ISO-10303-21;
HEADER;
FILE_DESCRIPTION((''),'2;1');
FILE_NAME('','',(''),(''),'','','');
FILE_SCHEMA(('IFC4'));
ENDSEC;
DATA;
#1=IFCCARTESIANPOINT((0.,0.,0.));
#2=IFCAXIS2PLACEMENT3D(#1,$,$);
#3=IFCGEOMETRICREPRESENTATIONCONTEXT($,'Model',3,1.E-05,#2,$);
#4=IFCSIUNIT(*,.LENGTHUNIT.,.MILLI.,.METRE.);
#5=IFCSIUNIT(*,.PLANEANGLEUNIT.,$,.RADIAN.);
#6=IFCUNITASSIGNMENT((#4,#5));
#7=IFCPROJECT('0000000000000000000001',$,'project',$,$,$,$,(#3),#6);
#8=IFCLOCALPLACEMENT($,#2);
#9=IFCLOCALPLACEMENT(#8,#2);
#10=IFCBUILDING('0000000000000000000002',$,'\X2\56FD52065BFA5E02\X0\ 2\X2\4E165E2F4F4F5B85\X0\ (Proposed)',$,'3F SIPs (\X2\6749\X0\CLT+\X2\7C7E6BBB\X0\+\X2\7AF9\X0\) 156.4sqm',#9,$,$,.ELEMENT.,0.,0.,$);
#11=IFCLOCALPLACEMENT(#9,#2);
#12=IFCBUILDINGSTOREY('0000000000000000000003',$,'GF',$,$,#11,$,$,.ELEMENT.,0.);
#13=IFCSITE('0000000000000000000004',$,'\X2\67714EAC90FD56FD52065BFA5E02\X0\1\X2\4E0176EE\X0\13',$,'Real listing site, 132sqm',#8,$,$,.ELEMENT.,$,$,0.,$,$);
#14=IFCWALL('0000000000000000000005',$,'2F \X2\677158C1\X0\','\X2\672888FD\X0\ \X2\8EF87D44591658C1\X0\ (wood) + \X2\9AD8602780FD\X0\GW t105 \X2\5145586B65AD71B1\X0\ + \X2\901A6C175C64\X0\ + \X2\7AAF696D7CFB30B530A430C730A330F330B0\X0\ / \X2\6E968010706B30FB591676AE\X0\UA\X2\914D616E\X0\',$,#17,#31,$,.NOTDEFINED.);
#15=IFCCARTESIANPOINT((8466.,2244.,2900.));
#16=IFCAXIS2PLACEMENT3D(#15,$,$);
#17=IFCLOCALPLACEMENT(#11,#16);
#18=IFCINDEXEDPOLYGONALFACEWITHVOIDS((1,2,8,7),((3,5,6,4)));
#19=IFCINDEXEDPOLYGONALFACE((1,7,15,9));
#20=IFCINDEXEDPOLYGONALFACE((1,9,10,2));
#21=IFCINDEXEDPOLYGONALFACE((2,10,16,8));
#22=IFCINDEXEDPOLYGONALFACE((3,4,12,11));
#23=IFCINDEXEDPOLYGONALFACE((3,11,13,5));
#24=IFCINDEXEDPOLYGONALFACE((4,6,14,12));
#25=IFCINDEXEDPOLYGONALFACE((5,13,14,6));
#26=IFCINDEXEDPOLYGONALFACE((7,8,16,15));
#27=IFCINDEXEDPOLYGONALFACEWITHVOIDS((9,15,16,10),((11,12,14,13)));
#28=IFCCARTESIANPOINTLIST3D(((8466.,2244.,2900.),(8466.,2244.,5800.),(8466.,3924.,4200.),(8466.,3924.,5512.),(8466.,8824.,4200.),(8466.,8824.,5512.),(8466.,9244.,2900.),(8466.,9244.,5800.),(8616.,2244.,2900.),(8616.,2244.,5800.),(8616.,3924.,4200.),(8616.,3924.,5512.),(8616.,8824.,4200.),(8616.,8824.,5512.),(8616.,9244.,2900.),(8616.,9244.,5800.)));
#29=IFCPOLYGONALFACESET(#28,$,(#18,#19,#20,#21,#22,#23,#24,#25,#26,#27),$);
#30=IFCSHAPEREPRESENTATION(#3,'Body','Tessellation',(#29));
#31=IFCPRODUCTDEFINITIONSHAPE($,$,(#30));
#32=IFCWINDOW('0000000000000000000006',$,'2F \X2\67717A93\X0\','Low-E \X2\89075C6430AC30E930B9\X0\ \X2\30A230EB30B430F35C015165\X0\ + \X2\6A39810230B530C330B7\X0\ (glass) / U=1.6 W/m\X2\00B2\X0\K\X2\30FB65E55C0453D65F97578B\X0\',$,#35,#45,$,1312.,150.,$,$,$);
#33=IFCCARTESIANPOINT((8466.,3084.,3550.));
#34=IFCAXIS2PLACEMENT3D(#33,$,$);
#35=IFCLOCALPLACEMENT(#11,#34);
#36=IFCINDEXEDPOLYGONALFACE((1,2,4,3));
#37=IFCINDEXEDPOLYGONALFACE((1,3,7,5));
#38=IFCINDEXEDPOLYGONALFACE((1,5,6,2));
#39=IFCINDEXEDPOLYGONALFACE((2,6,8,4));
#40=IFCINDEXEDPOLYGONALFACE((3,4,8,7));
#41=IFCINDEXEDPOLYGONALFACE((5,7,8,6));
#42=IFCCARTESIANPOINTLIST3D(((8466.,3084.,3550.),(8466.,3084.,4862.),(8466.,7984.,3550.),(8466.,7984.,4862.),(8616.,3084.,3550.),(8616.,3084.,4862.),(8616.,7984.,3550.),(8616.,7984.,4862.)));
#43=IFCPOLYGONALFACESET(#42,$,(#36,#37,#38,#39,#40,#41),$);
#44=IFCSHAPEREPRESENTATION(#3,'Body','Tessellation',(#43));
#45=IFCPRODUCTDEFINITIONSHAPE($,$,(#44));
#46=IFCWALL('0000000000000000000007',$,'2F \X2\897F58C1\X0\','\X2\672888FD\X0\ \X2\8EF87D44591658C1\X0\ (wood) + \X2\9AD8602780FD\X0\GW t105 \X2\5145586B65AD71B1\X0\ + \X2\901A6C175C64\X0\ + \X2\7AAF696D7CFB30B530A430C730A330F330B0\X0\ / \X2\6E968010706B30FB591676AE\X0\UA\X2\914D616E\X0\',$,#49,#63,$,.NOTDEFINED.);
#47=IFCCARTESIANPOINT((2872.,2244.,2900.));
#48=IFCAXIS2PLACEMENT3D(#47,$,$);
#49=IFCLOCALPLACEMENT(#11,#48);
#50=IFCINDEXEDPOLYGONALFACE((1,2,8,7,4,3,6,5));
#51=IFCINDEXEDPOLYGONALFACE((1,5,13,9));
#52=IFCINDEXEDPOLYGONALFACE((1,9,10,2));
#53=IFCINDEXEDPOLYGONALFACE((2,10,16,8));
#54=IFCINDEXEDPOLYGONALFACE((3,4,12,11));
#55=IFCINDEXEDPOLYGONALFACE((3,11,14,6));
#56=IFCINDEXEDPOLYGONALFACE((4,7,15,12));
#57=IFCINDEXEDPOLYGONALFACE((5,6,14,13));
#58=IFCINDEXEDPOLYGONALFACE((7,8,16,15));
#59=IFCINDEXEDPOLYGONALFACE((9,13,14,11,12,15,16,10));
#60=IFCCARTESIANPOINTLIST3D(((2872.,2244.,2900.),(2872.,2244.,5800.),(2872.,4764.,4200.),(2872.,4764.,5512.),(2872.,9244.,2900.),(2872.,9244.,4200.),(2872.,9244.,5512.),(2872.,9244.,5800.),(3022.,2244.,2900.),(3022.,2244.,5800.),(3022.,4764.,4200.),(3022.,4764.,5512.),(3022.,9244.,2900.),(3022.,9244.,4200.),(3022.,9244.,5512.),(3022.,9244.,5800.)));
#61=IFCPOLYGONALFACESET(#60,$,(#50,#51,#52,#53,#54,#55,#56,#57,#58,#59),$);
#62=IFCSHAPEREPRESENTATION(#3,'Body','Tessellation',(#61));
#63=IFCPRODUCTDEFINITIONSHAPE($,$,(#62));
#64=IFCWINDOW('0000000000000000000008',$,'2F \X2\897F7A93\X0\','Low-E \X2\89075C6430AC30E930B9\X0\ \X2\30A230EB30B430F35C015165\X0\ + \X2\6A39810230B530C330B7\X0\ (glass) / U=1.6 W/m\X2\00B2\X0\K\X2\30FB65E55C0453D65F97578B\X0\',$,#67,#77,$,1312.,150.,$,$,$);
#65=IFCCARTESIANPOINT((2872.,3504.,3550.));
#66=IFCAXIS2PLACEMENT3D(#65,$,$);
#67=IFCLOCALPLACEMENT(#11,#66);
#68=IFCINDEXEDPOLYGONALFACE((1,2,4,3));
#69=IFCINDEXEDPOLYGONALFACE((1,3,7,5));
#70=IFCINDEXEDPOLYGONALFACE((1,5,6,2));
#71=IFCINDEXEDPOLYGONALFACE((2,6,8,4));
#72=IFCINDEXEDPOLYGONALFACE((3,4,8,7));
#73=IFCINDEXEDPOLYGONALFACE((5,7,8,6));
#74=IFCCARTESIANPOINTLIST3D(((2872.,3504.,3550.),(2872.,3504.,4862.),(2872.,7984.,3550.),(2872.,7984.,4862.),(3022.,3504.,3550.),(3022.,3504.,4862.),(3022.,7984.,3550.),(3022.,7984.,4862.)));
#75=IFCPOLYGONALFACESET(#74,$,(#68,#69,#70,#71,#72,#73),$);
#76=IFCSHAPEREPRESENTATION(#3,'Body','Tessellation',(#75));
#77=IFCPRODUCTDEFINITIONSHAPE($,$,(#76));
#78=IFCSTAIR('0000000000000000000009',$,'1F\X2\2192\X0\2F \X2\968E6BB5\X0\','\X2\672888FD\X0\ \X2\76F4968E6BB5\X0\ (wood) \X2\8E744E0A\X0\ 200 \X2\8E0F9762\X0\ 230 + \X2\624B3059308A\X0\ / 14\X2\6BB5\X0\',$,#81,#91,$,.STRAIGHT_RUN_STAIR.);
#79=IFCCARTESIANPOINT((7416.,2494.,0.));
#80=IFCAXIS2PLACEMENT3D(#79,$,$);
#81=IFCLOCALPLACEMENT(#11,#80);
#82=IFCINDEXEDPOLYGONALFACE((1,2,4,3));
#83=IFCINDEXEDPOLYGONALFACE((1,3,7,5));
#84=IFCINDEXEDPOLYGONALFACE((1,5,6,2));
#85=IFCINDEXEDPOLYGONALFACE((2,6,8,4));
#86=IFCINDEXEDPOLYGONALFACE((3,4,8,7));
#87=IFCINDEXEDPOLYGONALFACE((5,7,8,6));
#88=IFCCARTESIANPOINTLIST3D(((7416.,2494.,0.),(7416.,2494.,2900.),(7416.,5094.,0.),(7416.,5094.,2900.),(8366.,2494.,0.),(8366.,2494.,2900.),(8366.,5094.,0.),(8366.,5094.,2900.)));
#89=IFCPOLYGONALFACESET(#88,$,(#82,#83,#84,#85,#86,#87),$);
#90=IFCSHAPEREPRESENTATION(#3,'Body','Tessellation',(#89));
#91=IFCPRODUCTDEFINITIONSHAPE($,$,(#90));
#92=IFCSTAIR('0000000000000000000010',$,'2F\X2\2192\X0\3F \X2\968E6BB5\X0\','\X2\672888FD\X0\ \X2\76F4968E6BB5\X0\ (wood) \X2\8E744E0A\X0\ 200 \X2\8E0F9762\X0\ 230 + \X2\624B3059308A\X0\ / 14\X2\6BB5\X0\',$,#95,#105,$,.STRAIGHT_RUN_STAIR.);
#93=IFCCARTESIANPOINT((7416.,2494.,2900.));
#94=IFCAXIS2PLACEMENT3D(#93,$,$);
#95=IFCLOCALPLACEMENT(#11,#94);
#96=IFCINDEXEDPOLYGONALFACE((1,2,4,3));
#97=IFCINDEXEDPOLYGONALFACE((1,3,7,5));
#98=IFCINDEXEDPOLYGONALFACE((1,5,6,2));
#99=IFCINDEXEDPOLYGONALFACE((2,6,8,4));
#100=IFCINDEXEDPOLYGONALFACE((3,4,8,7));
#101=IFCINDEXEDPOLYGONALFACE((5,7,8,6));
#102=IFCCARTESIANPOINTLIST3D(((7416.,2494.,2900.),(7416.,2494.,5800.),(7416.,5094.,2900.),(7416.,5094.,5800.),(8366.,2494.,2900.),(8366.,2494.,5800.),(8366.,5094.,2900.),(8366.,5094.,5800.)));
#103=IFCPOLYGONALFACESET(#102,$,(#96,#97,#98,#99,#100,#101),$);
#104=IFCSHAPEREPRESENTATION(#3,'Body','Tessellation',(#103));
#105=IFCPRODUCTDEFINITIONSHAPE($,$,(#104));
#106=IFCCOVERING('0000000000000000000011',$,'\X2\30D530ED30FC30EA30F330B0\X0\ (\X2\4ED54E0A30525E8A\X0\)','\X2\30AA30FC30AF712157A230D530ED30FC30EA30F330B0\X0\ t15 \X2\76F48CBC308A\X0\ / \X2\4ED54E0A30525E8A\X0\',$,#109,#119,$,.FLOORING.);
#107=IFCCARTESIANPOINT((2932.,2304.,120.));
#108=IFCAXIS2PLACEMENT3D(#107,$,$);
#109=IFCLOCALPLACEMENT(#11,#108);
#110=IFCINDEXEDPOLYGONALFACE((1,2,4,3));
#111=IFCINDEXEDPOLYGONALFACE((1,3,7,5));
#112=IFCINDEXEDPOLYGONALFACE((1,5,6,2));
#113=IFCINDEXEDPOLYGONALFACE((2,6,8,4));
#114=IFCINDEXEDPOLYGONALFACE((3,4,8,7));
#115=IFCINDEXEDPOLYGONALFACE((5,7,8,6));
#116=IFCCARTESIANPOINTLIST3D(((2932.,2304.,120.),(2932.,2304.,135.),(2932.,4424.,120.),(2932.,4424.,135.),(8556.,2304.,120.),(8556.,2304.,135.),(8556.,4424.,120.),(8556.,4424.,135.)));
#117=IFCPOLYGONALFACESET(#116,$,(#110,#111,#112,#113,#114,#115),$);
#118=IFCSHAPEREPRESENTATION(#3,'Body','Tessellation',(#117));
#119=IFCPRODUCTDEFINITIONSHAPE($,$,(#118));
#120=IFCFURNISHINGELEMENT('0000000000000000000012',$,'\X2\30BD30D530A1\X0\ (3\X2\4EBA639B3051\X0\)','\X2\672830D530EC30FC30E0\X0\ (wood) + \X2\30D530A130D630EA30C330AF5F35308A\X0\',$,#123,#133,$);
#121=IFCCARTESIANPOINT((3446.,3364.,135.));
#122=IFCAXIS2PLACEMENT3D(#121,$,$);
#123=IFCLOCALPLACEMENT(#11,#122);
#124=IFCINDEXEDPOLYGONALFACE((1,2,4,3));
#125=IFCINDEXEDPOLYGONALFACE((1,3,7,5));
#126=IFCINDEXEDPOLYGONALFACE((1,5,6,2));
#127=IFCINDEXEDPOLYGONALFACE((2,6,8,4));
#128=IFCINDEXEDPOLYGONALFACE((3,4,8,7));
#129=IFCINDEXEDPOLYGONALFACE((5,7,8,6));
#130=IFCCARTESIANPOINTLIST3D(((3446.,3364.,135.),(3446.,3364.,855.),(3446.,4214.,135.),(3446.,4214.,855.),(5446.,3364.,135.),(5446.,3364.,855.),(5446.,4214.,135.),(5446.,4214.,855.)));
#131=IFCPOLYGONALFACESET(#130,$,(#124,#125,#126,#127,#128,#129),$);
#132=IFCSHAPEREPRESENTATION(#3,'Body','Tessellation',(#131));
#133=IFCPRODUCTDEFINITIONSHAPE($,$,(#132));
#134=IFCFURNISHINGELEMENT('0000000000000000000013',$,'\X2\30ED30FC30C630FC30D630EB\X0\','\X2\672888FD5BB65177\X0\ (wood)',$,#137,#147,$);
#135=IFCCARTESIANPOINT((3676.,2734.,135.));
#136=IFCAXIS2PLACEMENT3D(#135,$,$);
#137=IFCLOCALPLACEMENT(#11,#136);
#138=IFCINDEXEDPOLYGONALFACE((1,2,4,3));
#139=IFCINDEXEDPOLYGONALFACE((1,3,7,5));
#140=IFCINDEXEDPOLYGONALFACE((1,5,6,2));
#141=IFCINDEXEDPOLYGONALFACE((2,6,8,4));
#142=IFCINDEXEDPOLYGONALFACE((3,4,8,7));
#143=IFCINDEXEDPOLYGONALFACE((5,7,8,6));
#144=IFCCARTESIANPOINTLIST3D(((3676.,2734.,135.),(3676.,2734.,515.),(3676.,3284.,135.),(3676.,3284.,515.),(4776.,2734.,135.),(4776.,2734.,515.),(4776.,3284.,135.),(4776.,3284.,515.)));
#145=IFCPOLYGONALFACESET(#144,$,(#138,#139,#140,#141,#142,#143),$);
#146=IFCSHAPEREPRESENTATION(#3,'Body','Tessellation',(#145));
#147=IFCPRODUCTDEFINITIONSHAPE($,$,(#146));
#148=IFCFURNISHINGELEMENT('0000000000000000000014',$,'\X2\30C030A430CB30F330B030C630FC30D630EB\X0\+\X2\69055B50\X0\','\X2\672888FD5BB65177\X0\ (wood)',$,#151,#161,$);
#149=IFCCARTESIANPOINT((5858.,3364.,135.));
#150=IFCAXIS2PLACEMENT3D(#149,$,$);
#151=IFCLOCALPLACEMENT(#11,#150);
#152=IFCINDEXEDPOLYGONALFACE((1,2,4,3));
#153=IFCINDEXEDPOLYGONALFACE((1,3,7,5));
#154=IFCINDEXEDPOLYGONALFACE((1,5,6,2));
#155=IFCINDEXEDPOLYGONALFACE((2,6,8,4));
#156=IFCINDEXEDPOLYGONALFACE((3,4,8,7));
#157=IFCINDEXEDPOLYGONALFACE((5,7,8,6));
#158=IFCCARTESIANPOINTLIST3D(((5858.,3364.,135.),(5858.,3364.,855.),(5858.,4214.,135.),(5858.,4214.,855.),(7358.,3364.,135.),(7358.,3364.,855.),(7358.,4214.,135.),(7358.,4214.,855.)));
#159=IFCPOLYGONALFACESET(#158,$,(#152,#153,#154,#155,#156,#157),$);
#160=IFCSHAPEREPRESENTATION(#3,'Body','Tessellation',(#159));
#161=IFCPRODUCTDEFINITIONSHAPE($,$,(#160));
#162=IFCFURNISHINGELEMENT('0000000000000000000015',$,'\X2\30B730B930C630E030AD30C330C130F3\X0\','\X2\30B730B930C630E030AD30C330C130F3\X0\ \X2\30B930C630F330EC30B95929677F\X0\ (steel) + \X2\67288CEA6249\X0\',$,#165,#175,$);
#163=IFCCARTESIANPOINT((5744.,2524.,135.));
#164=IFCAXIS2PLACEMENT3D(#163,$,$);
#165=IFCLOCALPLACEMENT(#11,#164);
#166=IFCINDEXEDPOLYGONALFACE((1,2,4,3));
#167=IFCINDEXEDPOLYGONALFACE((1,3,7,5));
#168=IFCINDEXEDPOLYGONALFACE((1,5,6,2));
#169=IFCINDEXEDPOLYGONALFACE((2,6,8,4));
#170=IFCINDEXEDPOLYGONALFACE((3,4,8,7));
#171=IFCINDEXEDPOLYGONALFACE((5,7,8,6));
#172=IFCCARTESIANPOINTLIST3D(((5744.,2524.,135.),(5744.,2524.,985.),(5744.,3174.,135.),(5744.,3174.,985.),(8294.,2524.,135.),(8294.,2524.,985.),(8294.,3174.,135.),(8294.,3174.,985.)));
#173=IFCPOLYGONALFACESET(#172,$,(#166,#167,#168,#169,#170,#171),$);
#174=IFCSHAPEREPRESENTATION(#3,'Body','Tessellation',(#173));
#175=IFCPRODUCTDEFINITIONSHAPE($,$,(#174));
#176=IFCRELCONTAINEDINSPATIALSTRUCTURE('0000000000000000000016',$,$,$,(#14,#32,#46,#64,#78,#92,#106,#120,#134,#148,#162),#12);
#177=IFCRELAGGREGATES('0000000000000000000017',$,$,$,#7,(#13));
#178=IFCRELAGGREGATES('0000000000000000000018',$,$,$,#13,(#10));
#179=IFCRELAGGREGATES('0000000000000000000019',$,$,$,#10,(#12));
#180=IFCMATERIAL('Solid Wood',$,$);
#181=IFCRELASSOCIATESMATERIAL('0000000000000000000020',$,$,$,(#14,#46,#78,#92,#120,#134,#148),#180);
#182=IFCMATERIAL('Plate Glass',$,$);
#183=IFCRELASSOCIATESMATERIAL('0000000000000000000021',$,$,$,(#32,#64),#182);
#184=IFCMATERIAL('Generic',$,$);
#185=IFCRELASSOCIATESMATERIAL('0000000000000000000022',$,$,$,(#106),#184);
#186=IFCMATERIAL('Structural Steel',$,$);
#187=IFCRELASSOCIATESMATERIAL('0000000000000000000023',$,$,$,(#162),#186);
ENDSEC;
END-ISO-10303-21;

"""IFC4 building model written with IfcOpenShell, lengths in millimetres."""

from ifc_helpers import new_model, si_unit, frame, frame_2d, origin, place, context, project, spatial, rectangle, extrude, material, element, fill, save


model = new_model("IFC4")

# Units and contexts
model_context = context("Model", 3, precision=1e-05, world=origin())
ifc_project = project(units=[si_unit("LENGTHUNIT", "METRE", prefix="MILLI"), si_unit("PLANEANGLEUNIT", "RADIAN")], contexts=[model_context])

# Site, building, storey
site_placement = place(None, origin())
site = spatial("IfcSite", under=ifc_project, at=site_placement, Name="東京都国分寺市1丁目13", ObjectType="Real listing site, 132sqm", CompositionType="ELEMENT", RefElevation=0.0)
building_placement = place(site_placement, origin())
building = spatial("IfcBuilding", under=site, at=building_placement, Name="国分寺市 2世帯住宅 (Proposed)", ObjectType="3F SIPs (杉CLT+籾殻+竹) 156.4sqm", CompositionType="ELEMENT", ElevationOfRefHeight=0.0, ElevationOfTerrain=0.0)
storey_placement = place(building_placement, origin())
storey = spatial("IfcBuildingStorey", under=building, at=storey_placement, Name="GF", CompositionType="ELEMENT", Elevation=0.0)

# Shared definitions
ifc_material_1 = material(Name="Solid Wood")
ifc_material_2 = material(Name="Generic")

# Shared definitions
ifc_material_3 = material(Name="Plate Glass")

# Walls, openings, windows
wall_1_placement = place(storey_placement, frame((8466.0, 2244.0, 2900.0)))
wall_1 = element("IfcWall", 1, at=wall_1_placement, inside=storey, material=ifc_material_1, Name="2F 東壁", Description="木製 軸組外壁 (wood) + 高性能GW t105 充填断熱 + 通気層 + 窯業系サイディング / 準耐火・外皮UA配慮", PredefinedType="NOTDEFINED", context=model_context, shape_type="SweptSolid", body=[
    extrude(rectangle(XDim=150.0, YDim=7000.0, at=frame_2d((75.0, 3500.0))), frame((8466.0, 2244.0, 2900.0)), (0.0, 0.0, 1.0), 2900.0),
])
opening_1_placement = place(storey_placement, frame((8466.0, 3084.0, 3550.0)))
opening_1 = element("IfcOpeningElement", 2, at=opening_1_placement, cuts=wall_1, PredefinedType="NOTDEFINED", context=model_context, shape_type="SweptSolid", body=[
    extrude(rectangle(XDim=150.0, YDim=4900.0, at=frame_2d((75.0, 2450.0))), frame((8466.0, 3084.0, 3550.0)), (0.0, 0.0, 1.0), 1312.0),
])
window_1_placement = place(storey_placement, frame((8466.0, 3084.0, 3550.0)))
window_1 = element("IfcWindow", 3, at=window_1_placement, inside=storey, material=ifc_material_3, Name="2F 東窓", Description="Low-E 複層ガラス アルゴン封入 + 樹脂サッシ (glass) / U=1.6 W/m²K・日射取得型", OverallHeight=1312.0, OverallWidth=150.0, context=model_context, shape_type="SweptSolid", body=[
    extrude(rectangle(XDim=150.0, YDim=4900.0, at=frame_2d((75.0, 2450.0))), frame((8466.0, 3084.0, 3550.0)), (0.0, 0.0, 1.0), 1312.0),
])
fill(opening_1, window_1)
wall_2_placement = place(storey_placement, frame((2872.0, 2244.0, 2900.0)))
wall_2 = element("IfcWall", 4, at=wall_2_placement, inside=storey, material=ifc_material_1, Name="2F 西壁", Description="木製 軸組外壁 (wood) + 高性能GW t105 充填断熱 + 通気層 + 窯業系サイディング / 準耐火・外皮UA配慮", PredefinedType="NOTDEFINED", context=model_context, shape_type="SweptSolid", body=[
    extrude(rectangle(XDim=150.0, YDim=7000.0, at=frame_2d((75.0, 3500.0))), frame((2872.0, 2244.0, 2900.0)), (0.0, 0.0, 1.0), 2900.0),
])
opening_2_placement = place(storey_placement, frame((2872.0, 3504.0, 3550.0)))
opening_2 = element("IfcOpeningElement", 5, at=opening_2_placement, cuts=wall_2, PredefinedType="NOTDEFINED", context=model_context, shape_type="SweptSolid", body=[
    extrude(rectangle(XDim=150.0, YDim=4480.0, at=frame_2d((75.0, 2240.0))), frame((2872.0, 3504.0, 3550.0)), (0.0, 0.0, 1.0), 1312.0),
])
window_2_placement = place(storey_placement, frame((2872.0, 3504.0, 3550.0)))
window_2 = element("IfcWindow", 6, at=window_2_placement, inside=storey, material=ifc_material_3, Name="2F 西窓", Description="Low-E 複層ガラス アルゴン封入 + 樹脂サッシ (glass) / U=1.6 W/m²K・日射取得型", OverallHeight=1312.0, OverallWidth=150.0, context=model_context, shape_type="SweptSolid", body=[
    extrude(rectangle(XDim=150.0, YDim=4480.0, at=frame_2d((75.0, 2240.0))), frame((2872.0, 3504.0, 3550.0)), (0.0, 0.0, 1.0), 1312.0),
])
fill(opening_2, window_2)

# Stairs
stair_1_placement = place(storey_placement, frame((7416.0, 2494.0, 0.0)))
element("IfcStair", 7, at=stair_1_placement, inside=storey, material=ifc_material_1, Name="1F→2F 階段", Description="木製 直階段 (wood) 蹴上 200 踏面 230 + 手すり / 14段", PredefinedType="STRAIGHT_RUN_STAIR", context=model_context, shape_type="SweptSolid", body=[
    extrude(rectangle(XDim=950.0, YDim=2600.0, at=frame_2d((475.0, 1300.0))), frame((7416.0, 2494.0, 0.0)), (0.0, 0.0, 1.0), 2900.0),
])
stair_2_placement = place(storey_placement, frame((7416.0, 2494.0, 2900.0)))
element("IfcStair", 8, at=stair_2_placement, inside=storey, material=ifc_material_1, Name="2F→3F 階段", Description="木製 直階段 (wood) 蹴上 200 踏面 230 + 手すり / 14段", PredefinedType="STRAIGHT_RUN_STAIR", context=model_context, shape_type="SweptSolid", body=[
    extrude(rectangle(XDim=950.0, YDim=2600.0, at=frame_2d((475.0, 1300.0))), frame((7416.0, 2494.0, 2900.0)), (0.0, 0.0, 1.0), 2900.0),
])

# Covering
covering_placement = place(storey_placement, frame((2932.0, 2304.0, 120.0)))
element("IfcCovering", 9, at=covering_placement, inside=storey, material=ifc_material_2, Name="フローリング (仕上げ床)", Description="オーク無垢フローリング t15 直貼り / 仕上げ床", PredefinedType="FLOORING", context=model_context, shape_type="SweptSolid", body=[
    extrude(rectangle(XDim=5624.0, YDim=2120.0, at=frame_2d((2812.0, 1060.0))), frame((2932.0, 2304.0, 120.0)), (0.0, 0.0, 1.0), 15.0),
])

# Furnishing elements
furnishing_1_placement = place(storey_placement, frame((3446.0, 3364.0, 135.0)))
element("IfcFurnishingElement", 10, at=furnishing_1_placement, inside=storey, material=ifc_material_1, Name="ソファ (3人掛け)", Description="木フレーム (wood) + ファブリック張り", context=model_context, shape_type="SweptSolid", body=[
    extrude(rectangle(XDim=2000.0, YDim=850.0, at=frame_2d((1000.0, 425.0))), frame((3446.0, 3364.0, 135.0)), (0.0, 0.0, 1.0), 720.0),
])
furnishing_2_placement = place(storey_placement, frame((3676.0, 2734.0, 135.0)))
element("IfcFurnishingElement", 11, at=furnishing_2_placement, inside=storey, material=ifc_material_1, Name="ローテーブル", Description="木製家具 (wood)", context=model_context, shape_type="SweptSolid", body=[
    extrude(rectangle(XDim=1100.0, YDim=550.0, at=frame_2d((550.0, 275.0))), frame((3676.0, 2734.0, 135.0)), (0.0, 0.0, 1.0), 380.0),
])
furnishing_3_placement = place(storey_placement, frame((5858.0, 3364.0, 135.0)))
element("IfcFurnishingElement", 12, at=furnishing_3_placement, inside=storey, material=ifc_material_1, Name="ダイニングテーブル+椅子", Description="木製家具 (wood)", context=model_context, shape_type="SweptSolid", body=[
    extrude(rectangle(XDim=1500.0, YDim=850.0, at=frame_2d((750.0, 425.0))), frame((5858.0, 3364.0, 135.0)), (0.0, 0.0, 1.0), 720.0),
])
ifc_material_4 = material(Name="Structural Steel")
furnishing_4_placement = place(storey_placement, frame((5744.0, 2524.0, 135.0)))
element("IfcFurnishingElement", 13, at=furnishing_4_placement, inside=storey, material=ifc_material_4, Name="システムキッチン", Description="システムキッチン ステンレス天板 (steel) + 木質扉", context=model_context, shape_type="SweptSolid", body=[
    extrude(rectangle(XDim=2550.0, YDim=650.0, at=frame_2d((1275.0, 325.0))), frame((5744.0, 2524.0, 135.0)), (0.0, 0.0, 1.0), 850.0),
])

save(model, "model.ifc")
